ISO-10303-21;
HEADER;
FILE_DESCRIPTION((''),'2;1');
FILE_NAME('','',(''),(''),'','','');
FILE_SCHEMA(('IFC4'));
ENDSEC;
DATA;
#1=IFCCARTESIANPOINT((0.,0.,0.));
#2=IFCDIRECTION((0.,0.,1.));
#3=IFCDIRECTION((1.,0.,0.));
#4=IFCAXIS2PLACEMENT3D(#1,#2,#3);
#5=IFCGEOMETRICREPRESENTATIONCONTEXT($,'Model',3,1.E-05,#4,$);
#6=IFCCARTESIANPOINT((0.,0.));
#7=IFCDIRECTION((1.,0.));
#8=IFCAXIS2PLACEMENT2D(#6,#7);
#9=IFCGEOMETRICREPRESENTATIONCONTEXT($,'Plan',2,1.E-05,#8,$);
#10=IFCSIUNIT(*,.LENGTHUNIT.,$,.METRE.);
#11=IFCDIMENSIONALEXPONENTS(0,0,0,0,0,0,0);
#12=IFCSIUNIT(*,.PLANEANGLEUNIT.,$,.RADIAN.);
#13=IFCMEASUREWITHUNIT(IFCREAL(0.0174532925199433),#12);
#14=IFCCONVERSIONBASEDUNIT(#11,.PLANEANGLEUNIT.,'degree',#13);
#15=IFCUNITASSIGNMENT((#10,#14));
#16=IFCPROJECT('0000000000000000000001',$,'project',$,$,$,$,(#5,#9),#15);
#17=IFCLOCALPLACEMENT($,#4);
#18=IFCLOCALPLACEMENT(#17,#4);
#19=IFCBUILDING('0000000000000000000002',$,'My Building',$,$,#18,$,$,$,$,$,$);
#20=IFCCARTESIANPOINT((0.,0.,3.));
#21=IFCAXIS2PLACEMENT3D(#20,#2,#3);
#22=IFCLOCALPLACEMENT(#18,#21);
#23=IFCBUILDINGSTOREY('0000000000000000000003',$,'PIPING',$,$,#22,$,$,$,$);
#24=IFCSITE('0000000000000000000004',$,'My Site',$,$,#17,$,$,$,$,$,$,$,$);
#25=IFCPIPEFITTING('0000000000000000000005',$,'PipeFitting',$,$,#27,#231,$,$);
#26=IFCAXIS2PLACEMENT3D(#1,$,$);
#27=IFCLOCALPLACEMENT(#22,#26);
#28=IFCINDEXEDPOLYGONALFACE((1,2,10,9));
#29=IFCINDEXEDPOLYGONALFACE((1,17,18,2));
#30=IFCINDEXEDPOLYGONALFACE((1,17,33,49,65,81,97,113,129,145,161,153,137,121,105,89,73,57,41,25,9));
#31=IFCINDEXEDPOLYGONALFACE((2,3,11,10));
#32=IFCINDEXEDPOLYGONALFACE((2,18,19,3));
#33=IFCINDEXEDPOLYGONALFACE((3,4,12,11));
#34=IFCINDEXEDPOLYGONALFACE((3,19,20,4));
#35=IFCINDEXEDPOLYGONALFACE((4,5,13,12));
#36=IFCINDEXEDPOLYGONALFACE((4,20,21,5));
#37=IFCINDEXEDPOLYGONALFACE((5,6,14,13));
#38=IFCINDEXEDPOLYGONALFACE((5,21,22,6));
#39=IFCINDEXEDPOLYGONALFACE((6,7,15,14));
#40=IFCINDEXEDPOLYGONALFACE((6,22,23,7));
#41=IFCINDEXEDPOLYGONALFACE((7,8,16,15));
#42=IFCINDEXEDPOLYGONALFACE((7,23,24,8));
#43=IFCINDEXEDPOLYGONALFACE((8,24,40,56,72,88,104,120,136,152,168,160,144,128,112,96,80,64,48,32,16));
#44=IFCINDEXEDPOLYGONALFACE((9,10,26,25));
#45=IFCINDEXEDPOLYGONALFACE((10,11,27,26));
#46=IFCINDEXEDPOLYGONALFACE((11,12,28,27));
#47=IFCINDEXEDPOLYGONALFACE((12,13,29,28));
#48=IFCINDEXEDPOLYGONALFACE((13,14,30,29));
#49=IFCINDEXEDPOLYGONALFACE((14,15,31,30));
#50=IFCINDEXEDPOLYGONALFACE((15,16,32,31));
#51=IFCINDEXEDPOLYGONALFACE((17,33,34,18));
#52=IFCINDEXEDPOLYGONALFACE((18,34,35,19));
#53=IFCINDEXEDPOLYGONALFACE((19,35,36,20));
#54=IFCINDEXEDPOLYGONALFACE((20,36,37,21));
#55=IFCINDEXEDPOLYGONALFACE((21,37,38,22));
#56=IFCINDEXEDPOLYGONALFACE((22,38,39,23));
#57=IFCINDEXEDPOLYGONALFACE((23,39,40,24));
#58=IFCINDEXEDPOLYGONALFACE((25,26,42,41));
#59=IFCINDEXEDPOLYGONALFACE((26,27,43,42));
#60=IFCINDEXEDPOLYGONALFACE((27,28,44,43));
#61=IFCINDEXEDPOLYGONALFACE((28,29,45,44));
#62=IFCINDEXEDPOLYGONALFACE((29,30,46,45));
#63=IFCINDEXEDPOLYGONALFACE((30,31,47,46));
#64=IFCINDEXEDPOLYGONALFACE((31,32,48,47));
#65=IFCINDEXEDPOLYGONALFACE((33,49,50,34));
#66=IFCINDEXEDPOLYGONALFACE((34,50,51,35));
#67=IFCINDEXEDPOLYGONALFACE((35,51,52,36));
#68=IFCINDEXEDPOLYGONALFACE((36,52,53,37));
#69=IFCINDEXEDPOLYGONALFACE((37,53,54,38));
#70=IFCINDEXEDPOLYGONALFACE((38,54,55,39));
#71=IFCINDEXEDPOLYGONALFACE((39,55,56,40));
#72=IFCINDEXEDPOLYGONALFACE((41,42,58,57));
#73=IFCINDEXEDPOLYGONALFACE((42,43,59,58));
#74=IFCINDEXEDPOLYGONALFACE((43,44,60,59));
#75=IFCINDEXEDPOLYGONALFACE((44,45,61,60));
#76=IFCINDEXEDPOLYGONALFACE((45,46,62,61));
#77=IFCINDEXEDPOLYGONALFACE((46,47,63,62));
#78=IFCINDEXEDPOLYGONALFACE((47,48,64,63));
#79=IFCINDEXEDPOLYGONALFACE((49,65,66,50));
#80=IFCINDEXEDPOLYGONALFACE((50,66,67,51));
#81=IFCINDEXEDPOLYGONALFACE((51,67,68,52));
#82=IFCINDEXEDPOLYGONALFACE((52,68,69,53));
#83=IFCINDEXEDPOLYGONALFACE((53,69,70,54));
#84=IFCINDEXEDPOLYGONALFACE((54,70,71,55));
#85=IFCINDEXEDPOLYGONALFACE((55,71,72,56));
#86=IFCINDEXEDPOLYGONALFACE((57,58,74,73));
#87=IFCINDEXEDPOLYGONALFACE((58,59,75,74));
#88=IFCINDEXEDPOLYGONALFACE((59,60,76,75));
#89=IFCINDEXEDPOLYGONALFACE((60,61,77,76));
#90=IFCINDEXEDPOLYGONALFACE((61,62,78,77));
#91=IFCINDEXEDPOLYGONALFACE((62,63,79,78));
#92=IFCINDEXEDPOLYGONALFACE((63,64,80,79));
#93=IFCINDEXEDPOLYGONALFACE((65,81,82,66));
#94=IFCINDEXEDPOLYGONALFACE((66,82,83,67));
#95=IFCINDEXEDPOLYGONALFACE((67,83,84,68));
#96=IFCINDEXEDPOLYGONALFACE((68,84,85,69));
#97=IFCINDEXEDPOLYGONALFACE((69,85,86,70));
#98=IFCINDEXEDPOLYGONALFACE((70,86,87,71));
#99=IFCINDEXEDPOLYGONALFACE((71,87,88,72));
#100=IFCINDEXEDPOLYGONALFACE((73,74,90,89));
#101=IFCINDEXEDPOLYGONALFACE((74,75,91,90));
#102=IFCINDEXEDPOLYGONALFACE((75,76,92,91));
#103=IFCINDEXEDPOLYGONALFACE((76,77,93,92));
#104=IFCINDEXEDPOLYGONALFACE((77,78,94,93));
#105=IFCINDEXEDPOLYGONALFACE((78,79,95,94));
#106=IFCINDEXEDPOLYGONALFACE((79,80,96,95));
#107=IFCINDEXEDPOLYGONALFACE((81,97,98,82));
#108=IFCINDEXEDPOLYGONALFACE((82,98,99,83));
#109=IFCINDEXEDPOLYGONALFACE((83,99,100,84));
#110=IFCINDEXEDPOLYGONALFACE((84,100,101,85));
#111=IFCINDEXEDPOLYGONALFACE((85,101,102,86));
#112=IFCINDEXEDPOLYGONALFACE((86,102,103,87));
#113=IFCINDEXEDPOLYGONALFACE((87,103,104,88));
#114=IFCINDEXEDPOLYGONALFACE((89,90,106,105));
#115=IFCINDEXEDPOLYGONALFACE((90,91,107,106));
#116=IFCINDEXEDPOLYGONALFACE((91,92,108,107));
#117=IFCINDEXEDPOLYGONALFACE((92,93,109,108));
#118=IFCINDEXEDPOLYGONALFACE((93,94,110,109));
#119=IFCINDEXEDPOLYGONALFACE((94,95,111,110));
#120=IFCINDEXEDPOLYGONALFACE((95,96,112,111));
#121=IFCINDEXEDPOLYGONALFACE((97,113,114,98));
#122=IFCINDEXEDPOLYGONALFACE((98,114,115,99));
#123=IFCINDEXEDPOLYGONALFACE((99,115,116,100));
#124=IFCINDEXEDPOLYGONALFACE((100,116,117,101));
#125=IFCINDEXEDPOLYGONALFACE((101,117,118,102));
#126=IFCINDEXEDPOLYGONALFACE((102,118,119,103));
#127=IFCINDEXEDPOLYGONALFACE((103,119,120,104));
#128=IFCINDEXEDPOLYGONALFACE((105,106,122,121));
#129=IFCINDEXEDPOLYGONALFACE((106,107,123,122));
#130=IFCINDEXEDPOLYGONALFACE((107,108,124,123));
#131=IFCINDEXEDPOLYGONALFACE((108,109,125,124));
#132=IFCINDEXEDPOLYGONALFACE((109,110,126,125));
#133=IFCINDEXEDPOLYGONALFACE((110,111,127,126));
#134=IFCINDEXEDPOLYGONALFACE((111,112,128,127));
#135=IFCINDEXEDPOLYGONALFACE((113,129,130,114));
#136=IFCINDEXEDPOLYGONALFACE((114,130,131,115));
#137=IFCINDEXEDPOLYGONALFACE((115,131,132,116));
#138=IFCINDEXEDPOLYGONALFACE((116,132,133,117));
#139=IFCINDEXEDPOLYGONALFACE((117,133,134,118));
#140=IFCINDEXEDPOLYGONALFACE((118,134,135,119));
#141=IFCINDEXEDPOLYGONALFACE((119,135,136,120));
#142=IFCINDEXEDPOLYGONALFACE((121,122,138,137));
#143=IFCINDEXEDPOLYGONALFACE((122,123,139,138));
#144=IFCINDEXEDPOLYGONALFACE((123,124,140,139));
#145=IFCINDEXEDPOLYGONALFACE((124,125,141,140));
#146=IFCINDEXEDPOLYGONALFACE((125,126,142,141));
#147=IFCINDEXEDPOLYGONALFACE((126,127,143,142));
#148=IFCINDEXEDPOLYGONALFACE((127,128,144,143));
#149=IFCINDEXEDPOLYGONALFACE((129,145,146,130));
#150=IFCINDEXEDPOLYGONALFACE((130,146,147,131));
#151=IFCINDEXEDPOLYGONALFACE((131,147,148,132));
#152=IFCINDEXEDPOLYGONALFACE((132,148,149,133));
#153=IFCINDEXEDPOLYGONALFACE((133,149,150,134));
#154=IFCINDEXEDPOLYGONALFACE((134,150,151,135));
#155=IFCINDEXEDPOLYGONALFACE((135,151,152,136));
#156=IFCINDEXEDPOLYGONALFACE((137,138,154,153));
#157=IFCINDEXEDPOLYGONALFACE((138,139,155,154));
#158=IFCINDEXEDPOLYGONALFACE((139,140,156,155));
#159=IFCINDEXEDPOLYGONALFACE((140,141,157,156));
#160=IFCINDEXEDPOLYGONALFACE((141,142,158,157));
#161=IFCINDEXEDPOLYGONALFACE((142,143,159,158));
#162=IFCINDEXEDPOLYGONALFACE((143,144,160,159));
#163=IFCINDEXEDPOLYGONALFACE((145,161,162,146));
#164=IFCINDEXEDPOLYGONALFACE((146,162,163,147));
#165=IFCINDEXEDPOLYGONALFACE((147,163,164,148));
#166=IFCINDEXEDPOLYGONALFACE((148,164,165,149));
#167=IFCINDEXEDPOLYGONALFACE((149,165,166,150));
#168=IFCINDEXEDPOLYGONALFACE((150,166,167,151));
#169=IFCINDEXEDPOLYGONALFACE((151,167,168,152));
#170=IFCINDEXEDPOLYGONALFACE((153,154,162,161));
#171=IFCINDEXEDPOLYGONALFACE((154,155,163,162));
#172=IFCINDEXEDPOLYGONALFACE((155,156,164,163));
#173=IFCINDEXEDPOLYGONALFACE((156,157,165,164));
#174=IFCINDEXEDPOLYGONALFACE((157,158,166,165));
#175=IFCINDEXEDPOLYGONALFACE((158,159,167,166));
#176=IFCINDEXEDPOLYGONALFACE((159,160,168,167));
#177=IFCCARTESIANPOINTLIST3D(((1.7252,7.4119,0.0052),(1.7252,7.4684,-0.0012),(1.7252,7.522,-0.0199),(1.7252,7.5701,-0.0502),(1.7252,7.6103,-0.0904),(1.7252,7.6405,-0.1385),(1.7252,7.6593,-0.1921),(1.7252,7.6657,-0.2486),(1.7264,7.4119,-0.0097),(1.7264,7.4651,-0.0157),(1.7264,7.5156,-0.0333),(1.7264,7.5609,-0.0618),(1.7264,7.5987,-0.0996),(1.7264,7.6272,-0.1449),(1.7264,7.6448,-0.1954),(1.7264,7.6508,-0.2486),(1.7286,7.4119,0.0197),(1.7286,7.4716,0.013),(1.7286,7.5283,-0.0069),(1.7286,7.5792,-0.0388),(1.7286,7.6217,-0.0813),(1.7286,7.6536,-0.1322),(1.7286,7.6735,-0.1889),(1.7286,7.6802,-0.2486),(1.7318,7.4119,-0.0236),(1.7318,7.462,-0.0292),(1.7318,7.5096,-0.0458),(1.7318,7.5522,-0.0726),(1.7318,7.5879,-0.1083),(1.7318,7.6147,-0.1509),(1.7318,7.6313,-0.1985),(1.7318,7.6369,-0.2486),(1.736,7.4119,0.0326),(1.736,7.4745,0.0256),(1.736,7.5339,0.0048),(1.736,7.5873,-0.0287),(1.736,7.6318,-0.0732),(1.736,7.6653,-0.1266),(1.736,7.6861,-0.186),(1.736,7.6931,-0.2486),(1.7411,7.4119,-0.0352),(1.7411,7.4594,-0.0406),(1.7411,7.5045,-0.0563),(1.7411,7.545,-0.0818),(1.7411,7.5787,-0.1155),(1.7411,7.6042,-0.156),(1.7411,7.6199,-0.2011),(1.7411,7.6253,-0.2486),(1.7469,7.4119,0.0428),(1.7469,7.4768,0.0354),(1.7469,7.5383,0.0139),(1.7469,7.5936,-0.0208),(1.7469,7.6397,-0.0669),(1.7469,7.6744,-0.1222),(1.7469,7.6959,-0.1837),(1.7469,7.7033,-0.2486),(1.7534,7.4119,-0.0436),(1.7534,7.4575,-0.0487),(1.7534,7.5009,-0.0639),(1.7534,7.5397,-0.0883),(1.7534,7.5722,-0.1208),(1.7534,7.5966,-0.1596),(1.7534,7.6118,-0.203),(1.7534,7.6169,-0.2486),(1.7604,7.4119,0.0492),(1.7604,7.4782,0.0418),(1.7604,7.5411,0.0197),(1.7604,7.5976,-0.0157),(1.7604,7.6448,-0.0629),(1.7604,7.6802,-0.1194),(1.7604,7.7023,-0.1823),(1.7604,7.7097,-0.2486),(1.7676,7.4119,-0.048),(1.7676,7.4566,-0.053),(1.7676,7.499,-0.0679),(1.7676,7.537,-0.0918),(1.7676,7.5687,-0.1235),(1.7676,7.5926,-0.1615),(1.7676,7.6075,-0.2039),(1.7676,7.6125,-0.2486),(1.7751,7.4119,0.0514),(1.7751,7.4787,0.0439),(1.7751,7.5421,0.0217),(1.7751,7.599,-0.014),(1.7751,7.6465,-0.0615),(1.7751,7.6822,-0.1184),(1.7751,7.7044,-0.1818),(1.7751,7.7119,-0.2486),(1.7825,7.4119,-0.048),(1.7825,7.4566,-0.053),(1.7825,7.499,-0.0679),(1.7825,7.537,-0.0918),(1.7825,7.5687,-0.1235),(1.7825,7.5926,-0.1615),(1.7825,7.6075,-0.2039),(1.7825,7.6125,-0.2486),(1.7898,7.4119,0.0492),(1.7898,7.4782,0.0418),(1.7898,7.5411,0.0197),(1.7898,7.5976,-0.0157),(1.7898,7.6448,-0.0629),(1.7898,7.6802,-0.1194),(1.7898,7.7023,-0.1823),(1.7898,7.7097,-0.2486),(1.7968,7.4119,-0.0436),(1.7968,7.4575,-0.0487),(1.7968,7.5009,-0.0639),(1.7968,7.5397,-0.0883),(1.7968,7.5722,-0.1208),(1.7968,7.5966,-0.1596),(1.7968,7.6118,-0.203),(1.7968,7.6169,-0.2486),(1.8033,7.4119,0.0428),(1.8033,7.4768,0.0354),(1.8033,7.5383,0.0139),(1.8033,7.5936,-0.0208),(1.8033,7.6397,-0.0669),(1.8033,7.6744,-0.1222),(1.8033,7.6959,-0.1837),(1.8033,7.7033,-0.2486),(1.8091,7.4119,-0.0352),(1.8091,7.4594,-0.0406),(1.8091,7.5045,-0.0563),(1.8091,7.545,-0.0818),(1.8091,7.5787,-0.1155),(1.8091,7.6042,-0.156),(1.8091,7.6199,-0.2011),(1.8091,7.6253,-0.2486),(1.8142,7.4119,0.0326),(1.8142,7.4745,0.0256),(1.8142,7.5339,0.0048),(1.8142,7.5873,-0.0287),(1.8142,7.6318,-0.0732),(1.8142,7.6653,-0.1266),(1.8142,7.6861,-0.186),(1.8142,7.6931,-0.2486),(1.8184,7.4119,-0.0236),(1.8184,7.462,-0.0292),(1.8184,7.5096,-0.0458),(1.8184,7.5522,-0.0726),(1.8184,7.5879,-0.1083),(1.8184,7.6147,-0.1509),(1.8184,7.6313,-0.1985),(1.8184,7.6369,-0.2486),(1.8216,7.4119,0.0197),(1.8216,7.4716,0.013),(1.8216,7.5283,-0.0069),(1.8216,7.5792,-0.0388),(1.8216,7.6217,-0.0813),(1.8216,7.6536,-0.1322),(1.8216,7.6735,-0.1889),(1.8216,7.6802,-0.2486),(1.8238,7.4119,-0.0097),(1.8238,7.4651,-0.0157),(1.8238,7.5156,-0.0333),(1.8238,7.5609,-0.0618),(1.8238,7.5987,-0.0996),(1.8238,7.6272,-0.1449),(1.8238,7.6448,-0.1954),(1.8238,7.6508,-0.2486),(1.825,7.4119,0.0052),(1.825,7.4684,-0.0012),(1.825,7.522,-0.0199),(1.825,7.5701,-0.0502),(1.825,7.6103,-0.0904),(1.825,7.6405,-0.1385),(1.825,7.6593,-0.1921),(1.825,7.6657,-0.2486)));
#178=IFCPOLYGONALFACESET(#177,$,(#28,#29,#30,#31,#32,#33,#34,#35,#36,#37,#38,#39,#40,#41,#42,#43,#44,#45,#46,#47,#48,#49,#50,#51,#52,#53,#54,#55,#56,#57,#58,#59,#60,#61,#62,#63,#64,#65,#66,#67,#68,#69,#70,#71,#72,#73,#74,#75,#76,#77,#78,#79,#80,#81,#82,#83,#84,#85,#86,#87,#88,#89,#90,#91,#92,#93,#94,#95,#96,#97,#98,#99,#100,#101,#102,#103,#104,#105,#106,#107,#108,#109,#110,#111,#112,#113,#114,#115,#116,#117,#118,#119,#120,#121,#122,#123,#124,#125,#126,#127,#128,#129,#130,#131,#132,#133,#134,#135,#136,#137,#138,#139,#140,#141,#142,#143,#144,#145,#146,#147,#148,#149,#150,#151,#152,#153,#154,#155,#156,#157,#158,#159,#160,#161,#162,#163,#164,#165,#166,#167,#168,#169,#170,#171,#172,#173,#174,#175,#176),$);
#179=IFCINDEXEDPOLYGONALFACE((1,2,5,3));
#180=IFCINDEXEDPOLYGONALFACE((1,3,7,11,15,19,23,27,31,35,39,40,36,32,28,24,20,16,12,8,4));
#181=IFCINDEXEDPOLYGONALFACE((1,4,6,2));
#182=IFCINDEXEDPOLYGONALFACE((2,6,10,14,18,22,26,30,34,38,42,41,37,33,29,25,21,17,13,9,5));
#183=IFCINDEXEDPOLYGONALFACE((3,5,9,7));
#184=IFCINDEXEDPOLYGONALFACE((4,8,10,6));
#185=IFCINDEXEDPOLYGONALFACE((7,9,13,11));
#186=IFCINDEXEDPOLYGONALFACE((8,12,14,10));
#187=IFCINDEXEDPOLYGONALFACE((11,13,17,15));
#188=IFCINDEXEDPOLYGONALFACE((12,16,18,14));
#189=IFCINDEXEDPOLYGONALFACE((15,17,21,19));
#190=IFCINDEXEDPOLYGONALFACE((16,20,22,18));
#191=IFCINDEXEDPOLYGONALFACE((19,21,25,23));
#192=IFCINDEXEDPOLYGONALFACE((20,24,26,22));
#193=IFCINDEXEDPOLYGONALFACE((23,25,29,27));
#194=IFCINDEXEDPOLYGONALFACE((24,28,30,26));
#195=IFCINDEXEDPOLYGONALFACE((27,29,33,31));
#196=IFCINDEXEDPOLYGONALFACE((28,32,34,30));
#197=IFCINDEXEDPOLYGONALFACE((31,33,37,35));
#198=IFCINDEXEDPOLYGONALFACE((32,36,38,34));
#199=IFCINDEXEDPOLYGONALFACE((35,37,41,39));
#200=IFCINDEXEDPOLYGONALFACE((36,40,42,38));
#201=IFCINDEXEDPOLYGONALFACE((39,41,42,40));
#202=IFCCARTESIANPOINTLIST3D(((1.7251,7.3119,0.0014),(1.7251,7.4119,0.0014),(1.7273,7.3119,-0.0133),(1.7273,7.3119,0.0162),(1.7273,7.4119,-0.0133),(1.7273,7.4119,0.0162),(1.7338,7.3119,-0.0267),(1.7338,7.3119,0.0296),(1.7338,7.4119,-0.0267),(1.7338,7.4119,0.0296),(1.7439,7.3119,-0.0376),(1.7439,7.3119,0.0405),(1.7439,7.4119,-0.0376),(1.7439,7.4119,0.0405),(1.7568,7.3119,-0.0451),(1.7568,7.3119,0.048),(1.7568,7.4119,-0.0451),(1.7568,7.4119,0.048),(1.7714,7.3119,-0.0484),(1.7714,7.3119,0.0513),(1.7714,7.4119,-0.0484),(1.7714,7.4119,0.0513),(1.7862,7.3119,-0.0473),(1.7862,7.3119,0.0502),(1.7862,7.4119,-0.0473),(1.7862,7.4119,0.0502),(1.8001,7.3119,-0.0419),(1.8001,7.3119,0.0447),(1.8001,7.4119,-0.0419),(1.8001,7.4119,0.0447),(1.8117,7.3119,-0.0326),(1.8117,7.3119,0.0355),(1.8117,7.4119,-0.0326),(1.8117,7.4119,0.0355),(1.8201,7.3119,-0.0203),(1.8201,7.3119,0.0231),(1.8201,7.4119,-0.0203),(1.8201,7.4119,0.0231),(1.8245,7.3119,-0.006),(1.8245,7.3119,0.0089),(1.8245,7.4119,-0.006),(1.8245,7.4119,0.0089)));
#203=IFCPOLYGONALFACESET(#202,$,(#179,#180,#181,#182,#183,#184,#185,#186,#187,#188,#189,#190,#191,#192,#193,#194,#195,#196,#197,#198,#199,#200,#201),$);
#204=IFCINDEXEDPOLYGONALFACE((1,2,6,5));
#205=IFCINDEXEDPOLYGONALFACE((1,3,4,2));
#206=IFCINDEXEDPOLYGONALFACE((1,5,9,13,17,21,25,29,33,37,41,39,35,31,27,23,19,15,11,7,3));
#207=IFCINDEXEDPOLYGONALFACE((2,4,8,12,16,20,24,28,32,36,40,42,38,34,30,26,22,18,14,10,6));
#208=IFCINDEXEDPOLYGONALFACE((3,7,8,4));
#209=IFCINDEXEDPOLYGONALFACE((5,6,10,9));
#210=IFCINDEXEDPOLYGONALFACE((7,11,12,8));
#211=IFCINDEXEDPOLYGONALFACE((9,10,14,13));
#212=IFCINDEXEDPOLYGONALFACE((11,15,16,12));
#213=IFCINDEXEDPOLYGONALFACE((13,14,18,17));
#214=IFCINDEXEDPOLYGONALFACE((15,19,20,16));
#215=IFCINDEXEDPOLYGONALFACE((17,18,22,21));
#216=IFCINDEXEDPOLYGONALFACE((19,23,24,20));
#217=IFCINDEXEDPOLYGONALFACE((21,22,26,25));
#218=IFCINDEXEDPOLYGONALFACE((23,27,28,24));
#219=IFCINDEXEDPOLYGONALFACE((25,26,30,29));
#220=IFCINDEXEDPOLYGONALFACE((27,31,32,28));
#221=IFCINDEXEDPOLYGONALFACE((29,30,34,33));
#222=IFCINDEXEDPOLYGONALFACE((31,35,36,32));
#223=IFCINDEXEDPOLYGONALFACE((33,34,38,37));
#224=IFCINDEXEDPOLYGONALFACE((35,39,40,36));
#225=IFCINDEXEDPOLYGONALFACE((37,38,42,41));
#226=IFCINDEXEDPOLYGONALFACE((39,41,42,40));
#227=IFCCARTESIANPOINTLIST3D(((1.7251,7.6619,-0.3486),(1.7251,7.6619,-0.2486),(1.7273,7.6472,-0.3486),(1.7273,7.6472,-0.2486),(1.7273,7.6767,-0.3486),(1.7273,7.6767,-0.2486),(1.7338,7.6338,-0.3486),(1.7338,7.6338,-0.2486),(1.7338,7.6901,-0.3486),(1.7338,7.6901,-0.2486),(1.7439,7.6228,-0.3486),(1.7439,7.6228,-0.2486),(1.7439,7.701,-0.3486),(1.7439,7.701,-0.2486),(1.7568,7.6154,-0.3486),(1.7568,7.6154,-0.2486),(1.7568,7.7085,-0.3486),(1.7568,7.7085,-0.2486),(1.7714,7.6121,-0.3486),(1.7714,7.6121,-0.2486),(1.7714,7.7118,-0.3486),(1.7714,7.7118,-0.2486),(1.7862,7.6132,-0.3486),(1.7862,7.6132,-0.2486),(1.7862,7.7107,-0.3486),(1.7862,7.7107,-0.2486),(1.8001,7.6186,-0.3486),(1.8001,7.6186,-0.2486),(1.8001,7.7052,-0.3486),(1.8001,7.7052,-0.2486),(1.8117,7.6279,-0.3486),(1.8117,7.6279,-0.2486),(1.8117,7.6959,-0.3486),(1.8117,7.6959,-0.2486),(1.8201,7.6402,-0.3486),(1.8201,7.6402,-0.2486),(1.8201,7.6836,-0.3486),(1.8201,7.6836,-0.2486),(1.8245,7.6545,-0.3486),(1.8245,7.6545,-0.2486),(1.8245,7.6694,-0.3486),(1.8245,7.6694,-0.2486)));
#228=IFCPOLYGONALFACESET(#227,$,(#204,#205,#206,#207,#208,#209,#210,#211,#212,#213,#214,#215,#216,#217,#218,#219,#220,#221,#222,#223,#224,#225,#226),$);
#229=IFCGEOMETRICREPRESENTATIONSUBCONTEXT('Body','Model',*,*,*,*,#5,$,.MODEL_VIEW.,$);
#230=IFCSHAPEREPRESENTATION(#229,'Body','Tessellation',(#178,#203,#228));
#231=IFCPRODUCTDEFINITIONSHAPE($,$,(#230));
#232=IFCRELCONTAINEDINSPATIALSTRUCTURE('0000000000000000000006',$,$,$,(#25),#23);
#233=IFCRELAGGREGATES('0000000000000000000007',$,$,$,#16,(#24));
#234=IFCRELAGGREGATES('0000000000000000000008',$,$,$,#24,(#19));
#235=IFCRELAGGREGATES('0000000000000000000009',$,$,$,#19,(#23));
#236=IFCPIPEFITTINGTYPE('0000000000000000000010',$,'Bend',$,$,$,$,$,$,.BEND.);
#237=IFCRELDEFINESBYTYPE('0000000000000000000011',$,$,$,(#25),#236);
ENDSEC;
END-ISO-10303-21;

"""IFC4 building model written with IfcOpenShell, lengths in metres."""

from ifc_helpers import new_model, entity, si_unit, converted_unit, frame, origin_with_axes, origin_2d_with_axis, place, context, subcontext, project, spatial, circle, extrude, source, transform, mapped, type_object, type_shapes, element, save


model = new_model("IFC4")

# Units and contexts
model_context = context("Model", 3, precision=1e-05, world=origin_with_axes())
plan_context = context("Plan", 2, precision=1e-05, world=origin_2d_with_axis())
body_context = subcontext(model_context, "Body", "Model", "MODEL_VIEW")
ifc_project = project(units=[si_unit("LENGTHUNIT", "METRE"), converted_unit("PLANEANGLEUNIT", "degree", entity("IfcReal", 0.0174532925199433), si_unit("PLANEANGLEUNIT", "RADIAN"), dimensions=[0, 0, 0, 0, 0, 0, 0])], contexts=[model_context, plan_context])

# Site, building, storey
site_placement = place(None, origin_with_axes())
site = spatial("IfcSite", under=ifc_project, at=site_placement, Name="My Site")
building_placement = place(site_placement, origin_with_axes())
building = spatial("IfcBuilding", under=site, at=building_placement, Name="My Building")
storey_placement = place(building_placement, frame((0.0, 0.0, 3.0), z_axis=(0.0, 0.0, 1.0), x_axis=(1.0, 0.0, 0.0)))
storey = spatial("IfcBuildingStorey", under=building, at=storey_placement, Name="PIPING")

# Pipe fitting
pipe_fitting_type = type_object("IfcPipeFittingType", Name="Bend", PredefinedType="BEND")
shared_shape = source(origin_with_axes(), body_context, "Body", "SolidModel", [
    entity("IfcSweptDiskSolid", entity("IfcIndexedPolyCurve", entity("IfcCartesianPointList3D", [[0.0, 0.0, -0.1], [0.0, 0.0732, -0.2768], [0.0, 0.25, -0.35]]), [entity("IfcArcIndex", [1, 2, 3])]), 0.05),
    extrude(circle(Radius=0.05), origin_with_axes(), (0.0, 0.0, -1.0), 0.1),
    extrude(circle(Radius=0.05), frame((0.0, 0.25, -0.35), z_axis=(0.0, 1.0, 0.0), x_axis=(1.0, 0.0, 0.0)), (0.0, 0.0, 1.0), 0.1),
])
type_shapes(pipe_fitting_type, [shared_shape])
for number, where, z_axis, x_axis, name in (
    (1, (1.7751, 7.3119, 0.0014), (0.0, -1.0, 0.0), (-1.0, 0.0, 0.0), "PipeFitting"),
):
    element("IfcPipeFitting", number, at=place(storey_placement, frame(where, z_axis=z_axis, x_axis=x_axis)), inside=storey, type_object=pipe_fitting_type, Name=name, context=body_context, shape_type="MappedRepresentation", body=[
        mapped(shared_shape, transform((0.0, 0.0, 0.0), x_axis=(1.0, 0.0, 0.0), y_axis=(0.0, 1.0, 0.0), z_axis=(0.0, 0.0, 1.0), scale=1.0)),
    ])

save(model, "model.ifc")
